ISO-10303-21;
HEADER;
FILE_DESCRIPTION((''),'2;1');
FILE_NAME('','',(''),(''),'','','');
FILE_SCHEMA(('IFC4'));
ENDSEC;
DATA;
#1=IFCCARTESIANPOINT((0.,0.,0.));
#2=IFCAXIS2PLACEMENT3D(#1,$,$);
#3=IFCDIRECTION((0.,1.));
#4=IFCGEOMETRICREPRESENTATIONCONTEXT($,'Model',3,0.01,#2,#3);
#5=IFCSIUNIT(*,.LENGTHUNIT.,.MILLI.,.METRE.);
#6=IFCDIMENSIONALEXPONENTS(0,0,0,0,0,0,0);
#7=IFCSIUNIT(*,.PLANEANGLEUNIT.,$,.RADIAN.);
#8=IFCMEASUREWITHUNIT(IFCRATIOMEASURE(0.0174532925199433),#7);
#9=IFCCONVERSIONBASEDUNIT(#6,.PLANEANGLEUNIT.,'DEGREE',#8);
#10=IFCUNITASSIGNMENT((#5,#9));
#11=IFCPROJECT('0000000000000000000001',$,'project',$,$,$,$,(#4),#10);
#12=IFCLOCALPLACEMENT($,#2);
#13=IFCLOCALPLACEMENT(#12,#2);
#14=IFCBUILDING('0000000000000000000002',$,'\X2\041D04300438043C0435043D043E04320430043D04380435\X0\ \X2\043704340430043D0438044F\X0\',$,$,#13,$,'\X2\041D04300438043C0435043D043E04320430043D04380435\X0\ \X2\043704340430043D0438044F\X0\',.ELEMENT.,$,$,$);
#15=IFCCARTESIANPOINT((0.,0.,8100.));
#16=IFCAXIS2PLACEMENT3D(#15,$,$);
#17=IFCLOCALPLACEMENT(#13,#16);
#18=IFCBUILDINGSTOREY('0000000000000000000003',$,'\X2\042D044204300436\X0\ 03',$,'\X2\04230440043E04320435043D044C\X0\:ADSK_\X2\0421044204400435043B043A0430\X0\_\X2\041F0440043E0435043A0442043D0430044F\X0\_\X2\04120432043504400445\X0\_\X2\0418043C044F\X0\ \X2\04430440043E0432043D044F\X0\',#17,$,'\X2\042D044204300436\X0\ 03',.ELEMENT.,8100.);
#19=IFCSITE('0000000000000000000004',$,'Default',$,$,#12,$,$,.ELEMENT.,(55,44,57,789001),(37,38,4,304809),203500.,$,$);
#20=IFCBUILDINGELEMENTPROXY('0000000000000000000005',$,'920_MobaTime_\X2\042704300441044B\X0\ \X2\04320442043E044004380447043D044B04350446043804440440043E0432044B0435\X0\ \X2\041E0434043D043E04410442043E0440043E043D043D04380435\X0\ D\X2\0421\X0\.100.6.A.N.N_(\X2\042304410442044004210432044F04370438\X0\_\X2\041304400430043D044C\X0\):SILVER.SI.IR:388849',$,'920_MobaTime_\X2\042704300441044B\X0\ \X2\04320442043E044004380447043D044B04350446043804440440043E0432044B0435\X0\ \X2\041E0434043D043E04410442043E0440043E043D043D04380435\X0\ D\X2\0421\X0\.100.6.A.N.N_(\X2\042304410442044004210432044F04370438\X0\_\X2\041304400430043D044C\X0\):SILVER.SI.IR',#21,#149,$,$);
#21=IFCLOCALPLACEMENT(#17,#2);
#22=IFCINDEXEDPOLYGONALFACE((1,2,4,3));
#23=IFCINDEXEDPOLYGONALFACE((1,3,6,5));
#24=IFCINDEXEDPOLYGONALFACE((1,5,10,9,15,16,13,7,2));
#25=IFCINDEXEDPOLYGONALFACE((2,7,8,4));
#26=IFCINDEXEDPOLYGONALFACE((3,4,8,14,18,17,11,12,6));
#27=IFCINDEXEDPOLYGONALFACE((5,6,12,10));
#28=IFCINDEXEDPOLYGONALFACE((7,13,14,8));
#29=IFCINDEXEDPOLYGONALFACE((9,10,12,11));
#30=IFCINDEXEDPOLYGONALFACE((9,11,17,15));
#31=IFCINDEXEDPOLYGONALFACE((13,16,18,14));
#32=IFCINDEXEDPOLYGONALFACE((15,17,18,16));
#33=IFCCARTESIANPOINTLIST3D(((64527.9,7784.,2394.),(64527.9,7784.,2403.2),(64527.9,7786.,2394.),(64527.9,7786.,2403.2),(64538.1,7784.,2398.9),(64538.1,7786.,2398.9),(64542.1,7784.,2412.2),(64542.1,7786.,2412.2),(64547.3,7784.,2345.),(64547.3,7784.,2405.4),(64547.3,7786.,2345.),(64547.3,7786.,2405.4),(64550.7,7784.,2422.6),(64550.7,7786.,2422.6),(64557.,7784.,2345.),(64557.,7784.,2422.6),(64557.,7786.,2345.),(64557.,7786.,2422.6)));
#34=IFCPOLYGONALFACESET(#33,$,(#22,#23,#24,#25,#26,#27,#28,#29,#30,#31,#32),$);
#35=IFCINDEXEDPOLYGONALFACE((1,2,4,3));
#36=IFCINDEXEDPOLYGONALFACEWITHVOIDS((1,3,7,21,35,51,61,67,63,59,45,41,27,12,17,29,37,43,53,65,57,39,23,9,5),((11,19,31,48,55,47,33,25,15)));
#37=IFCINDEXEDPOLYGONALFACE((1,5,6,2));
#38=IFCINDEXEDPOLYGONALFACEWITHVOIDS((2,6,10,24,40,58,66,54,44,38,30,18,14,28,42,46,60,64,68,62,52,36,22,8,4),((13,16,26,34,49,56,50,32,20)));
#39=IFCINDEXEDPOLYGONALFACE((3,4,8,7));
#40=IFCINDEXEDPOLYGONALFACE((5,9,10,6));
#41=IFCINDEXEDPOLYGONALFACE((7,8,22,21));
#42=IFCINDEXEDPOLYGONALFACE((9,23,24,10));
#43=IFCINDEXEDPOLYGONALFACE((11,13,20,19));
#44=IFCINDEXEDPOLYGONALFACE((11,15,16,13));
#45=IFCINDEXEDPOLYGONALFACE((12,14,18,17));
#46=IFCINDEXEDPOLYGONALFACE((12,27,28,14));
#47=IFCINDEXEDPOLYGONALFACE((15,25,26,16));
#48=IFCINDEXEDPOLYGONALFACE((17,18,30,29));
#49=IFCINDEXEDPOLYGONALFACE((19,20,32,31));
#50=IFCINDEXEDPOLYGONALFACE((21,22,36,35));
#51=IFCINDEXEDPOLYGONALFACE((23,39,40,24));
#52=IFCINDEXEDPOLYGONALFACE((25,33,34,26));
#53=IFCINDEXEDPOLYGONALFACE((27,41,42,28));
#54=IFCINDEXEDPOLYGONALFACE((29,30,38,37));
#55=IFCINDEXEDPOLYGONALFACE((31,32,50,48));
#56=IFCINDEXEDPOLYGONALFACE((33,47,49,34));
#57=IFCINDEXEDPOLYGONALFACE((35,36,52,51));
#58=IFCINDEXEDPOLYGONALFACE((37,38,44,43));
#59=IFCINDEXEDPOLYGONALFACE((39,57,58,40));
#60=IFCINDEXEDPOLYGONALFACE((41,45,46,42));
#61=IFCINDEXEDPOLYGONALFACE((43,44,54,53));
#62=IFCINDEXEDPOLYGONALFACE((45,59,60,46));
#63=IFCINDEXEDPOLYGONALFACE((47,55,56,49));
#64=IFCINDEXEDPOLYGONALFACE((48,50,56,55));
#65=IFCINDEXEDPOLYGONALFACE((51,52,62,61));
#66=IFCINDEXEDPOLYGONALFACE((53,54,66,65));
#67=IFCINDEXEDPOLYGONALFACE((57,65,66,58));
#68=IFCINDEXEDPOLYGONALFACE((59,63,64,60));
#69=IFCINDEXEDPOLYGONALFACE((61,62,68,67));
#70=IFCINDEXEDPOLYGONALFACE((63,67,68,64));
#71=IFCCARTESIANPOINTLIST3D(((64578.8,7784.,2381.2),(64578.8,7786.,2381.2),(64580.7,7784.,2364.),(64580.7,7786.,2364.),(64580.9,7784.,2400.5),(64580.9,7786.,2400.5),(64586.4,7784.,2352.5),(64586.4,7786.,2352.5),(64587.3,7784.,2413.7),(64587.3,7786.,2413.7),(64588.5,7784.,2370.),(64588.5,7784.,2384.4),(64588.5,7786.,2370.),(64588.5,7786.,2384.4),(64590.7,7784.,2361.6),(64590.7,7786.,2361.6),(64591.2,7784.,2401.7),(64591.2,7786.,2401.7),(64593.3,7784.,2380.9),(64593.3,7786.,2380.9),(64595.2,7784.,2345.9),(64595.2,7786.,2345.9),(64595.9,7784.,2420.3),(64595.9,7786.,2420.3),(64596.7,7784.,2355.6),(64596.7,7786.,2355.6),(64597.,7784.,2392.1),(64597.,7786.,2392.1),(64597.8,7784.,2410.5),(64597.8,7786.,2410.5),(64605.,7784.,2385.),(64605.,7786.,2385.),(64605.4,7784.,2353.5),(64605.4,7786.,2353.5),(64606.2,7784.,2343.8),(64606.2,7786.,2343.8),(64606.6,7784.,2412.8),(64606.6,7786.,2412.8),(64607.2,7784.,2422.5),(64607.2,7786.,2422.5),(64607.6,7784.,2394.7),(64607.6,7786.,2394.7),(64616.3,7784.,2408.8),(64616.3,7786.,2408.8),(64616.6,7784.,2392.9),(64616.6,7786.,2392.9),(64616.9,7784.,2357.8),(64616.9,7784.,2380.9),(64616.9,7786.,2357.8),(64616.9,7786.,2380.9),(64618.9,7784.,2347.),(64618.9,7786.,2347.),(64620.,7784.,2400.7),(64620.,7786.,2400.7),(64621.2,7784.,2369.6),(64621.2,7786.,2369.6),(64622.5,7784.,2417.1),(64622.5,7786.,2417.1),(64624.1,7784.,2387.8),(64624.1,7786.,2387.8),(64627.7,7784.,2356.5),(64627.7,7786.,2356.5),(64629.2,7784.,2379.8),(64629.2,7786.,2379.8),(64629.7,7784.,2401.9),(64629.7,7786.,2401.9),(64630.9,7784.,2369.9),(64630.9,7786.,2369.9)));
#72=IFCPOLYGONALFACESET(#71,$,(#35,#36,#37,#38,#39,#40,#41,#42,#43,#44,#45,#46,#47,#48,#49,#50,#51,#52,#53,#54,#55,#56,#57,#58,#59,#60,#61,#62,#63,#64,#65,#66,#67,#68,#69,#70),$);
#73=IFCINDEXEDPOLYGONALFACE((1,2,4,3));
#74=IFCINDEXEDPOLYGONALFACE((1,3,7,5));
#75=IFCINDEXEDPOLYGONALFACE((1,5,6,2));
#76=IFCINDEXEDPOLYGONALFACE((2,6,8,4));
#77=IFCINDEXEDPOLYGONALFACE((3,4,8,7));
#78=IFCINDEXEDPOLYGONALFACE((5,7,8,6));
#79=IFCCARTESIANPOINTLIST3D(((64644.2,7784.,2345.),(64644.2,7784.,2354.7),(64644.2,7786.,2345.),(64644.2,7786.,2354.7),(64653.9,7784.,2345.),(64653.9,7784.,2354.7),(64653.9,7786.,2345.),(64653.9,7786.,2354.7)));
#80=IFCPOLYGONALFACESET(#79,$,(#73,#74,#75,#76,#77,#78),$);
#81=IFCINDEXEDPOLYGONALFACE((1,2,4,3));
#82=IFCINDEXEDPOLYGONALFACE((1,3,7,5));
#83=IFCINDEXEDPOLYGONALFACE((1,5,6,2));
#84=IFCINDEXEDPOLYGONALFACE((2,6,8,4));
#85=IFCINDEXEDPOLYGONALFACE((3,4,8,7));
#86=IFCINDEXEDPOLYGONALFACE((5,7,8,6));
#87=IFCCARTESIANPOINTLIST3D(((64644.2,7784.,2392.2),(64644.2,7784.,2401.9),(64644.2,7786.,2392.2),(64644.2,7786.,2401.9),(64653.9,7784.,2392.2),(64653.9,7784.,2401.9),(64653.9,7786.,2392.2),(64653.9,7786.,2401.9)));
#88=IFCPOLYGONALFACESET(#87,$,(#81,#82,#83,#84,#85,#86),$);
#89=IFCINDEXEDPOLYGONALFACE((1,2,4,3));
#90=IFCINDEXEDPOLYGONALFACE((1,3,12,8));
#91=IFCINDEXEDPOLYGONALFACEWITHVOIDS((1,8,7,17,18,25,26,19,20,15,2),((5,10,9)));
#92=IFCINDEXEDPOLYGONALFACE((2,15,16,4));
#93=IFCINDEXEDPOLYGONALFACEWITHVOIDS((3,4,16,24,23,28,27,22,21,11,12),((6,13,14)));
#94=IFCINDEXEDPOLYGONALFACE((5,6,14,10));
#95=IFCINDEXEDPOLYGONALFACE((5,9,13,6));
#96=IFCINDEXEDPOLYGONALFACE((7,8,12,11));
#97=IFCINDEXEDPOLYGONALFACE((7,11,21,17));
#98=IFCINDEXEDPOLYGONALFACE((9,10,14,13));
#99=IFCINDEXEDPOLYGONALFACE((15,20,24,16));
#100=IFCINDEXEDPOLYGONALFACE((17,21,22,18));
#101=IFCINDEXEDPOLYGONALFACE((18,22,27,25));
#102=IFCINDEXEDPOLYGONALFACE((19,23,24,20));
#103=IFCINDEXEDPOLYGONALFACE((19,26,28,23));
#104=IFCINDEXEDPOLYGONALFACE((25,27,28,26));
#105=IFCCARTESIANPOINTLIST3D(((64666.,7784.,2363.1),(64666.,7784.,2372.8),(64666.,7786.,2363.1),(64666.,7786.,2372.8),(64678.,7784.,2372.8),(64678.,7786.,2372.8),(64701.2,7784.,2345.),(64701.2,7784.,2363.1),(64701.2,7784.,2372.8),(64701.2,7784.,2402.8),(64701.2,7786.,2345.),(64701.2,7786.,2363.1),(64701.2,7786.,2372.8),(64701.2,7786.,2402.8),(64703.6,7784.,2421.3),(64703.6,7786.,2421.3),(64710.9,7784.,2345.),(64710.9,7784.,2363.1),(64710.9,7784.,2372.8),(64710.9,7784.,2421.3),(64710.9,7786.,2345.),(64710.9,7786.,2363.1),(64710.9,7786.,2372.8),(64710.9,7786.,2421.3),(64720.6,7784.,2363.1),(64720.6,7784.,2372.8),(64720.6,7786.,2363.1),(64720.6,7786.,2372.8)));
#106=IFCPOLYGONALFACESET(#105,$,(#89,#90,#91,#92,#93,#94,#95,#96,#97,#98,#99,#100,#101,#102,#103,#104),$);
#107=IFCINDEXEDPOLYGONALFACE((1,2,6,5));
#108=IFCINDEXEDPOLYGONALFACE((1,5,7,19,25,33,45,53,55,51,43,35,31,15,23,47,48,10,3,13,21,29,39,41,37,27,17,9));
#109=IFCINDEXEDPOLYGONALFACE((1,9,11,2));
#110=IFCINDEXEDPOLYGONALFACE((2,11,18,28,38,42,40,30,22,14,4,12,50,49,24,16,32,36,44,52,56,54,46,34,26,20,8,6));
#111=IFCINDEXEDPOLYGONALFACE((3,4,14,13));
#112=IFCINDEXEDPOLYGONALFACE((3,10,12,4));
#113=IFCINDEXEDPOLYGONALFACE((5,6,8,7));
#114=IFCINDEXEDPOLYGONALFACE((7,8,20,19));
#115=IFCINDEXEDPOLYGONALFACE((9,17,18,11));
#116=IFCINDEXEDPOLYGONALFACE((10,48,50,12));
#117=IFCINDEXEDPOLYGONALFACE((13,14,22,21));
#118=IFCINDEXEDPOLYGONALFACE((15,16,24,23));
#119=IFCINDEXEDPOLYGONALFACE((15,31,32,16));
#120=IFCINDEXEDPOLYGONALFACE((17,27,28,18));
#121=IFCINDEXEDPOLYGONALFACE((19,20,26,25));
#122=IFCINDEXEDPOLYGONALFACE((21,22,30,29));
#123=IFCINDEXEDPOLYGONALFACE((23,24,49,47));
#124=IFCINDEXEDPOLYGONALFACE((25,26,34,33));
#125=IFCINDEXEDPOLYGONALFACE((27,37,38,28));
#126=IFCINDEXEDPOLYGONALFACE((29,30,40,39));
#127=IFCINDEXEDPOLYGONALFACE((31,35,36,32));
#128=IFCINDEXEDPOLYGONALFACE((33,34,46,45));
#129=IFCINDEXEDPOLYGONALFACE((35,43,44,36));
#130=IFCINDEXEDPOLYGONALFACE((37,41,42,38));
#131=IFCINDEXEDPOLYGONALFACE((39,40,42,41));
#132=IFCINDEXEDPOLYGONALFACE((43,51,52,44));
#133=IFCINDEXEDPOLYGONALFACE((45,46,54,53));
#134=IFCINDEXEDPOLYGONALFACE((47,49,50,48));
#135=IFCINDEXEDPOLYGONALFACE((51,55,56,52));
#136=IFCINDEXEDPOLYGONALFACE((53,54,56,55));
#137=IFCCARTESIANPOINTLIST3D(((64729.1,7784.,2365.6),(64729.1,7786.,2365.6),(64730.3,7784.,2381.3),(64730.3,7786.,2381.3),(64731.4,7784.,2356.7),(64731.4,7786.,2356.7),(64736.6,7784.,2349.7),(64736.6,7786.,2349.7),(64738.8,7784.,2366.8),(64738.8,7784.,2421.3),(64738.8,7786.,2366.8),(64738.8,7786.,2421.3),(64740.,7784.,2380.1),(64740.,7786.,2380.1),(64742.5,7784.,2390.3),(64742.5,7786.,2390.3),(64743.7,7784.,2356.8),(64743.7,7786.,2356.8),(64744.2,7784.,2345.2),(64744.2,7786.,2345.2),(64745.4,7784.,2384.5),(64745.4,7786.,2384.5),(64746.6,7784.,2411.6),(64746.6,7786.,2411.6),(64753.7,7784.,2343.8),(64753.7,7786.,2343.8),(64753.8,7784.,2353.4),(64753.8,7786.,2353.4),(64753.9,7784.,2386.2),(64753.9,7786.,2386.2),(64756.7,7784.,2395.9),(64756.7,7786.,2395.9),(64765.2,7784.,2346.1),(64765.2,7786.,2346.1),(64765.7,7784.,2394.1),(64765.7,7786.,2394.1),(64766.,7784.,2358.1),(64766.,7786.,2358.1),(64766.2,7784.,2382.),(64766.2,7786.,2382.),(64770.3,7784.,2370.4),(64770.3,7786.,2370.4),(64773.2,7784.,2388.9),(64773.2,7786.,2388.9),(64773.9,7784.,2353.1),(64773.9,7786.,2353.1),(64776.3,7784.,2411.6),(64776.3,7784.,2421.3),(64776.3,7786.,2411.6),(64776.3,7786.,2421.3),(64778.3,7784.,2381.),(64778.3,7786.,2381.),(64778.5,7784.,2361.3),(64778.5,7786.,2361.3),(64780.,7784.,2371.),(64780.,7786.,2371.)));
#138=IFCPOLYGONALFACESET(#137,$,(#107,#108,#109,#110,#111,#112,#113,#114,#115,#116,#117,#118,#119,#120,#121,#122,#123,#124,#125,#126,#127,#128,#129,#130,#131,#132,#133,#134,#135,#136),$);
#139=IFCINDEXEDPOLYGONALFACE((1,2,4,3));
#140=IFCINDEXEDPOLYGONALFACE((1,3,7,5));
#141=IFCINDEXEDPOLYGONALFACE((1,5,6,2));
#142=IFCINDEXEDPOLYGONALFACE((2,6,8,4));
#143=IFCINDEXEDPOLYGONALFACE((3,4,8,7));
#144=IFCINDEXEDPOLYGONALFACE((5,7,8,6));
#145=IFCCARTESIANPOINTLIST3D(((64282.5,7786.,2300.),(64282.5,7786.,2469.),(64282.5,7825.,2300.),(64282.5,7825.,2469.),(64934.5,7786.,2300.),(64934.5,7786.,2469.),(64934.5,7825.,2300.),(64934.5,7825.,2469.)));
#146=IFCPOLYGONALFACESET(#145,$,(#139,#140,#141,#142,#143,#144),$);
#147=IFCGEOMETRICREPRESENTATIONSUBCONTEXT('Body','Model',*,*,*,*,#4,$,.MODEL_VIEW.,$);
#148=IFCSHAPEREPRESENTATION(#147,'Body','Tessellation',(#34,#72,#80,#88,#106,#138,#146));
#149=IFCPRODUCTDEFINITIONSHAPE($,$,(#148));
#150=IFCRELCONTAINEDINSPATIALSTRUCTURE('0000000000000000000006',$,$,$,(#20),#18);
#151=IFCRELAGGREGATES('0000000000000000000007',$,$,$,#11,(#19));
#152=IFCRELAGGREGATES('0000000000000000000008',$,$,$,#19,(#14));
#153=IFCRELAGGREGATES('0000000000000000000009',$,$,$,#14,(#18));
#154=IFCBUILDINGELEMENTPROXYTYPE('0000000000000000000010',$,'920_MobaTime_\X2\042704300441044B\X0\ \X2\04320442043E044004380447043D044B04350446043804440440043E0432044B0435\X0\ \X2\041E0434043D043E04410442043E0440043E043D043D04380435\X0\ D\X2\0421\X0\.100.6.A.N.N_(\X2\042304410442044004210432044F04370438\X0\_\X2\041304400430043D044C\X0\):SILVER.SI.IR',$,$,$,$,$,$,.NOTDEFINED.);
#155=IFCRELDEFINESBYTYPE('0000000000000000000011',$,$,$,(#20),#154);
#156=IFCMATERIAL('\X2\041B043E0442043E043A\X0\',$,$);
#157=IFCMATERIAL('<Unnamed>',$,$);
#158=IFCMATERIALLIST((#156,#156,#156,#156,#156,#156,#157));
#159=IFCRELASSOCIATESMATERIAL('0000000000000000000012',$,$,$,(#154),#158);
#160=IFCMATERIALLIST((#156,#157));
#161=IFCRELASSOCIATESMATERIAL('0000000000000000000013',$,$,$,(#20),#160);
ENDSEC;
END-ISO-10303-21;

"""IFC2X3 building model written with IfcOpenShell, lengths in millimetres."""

from ifc_helpers import new_model, entity, si_unit, converted_unit, direction, frame, origin, origin_2d_with_axis, place, context, subcontext, project, spatial, polyline, rectangle, outline, extrude, source, transform, mapped, material, material_list, type_object, type_shapes, element, save


model = new_model("IFC2X3")

# Units and contexts
model_context = context("Model", 3, precision=0.01, world=origin(), true_north=direction((0.0, 1.0)))
body_context = subcontext(model_context, "Body", "Model", "MODEL_VIEW")
ifc_project = project(units=[si_unit("LENGTHUNIT", "METRE", prefix="MILLI"), converted_unit("PLANEANGLEUNIT", "DEGREE", entity("IfcRatioMeasure", 0.0174532925199433), si_unit("PLANEANGLEUNIT", "RADIAN"), dimensions=[0, 0, 0, 0, 0, 0, 0])], contexts=[model_context])

# Site, building, storey
site_placement = place(None, origin())
site = spatial("IfcSite", under=ifc_project, at=site_placement, Name="Default", CompositionType="ELEMENT", RefLatitude=(55, 44, 57, 789001), RefLongitude=(37, 38, 4, 304809), RefElevation=203500.0)
building_placement = place(site_placement, origin())
building = spatial("IfcBuilding", under=site, at=building_placement, Name="Наименование здания", LongName="Наименование здания", CompositionType="ELEMENT")
storey_placement = place(building_placement, frame((0.0, 0.0, 8100.0)))
storey = spatial("IfcBuildingStorey", under=building, at=storey_placement, Name="Этаж 03", ObjectType="Уровень:ADSK_Стрелка_Проектная_Вверх_Имя уровня", LongName="Этаж 03", CompositionType="ELEMENT", Elevation=8100.0)

# Building element proxy
ifc_material_1 = material(Name="Лоток")
ifc_material_2 = material(Name="<Unnamed>")
ifc_material_list_1 = material_list([ifc_material_1, ifc_material_1, ifc_material_1, ifc_material_1, ifc_material_1, ifc_material_1, ifc_material_2])
building_element_proxy_type = type_object("IfcBuildingElementProxyType", Name="920_MobaTime_Часы вторичныецифровые Односторонние DС.100.6.A.N.N_(УстрСвязи_Грань):SILVER.SI.IR", PredefinedType="NOTDEFINED", material=ifc_material_list_1)
shared_shape = source(origin(), body_context, "Body", "SweptSolid", [
    extrude(outline(polyline([(-49.3, -13.1), (28.2, -13.1), (28.2, -6.8), (17.9, 1.8), (8.8, 16.0), (-0.3, 16.0), (4.6, 5.8), (11.1, -3.4), (-49.3, -3.4), (-49.3, -13.1)])), frame((-64.6, 9.8, 39.0), z_axis=(0.0, 0.0, 1.0), x_axis=(0.0, 1.0, 0.0)), (0.0, 0.0, 1.0), 2.0),
    extrude(outline(polyline([(2.2, -27.6), (19.0, -27.6), (30.5, -16.1), (33.3, -4.9), (31.0, 5.8), (21.8, 17.2), (5.2, 27.3), (-11.1, 33.0), (-24.0, 32.7), (-33.6, 27.6), (-40.3, 18.6), (-42.8, 5.7), (-38.0, -6.3), (-27.2, -14.9), (-17.5, -17.7), (-8.2, -16.4), (-0.3, -11.9), (5.1, -4.5), (7.3, 6.2), (4.0, 17.2), (18.4, 7.3), (23.6, -2.4), (22.0, -11.4), (14.2, -18.4), (5.3, -18.3), (2.2, -27.6)]), holes=[polyline([(-9.0, 23.3), (-1.3, 14.3), (-2.5, 2.0), (-11.4, -7.0), (-23.4, -6.0), (-32.2, 2.9), (-31.2, 15.1), (-25.6, 22.1), (-17.5, 24.9), (-9.0, 23.3)])]), frame((-2.7, 3.6, 39.0), z_axis=(0.0, 0.0, 1.0), x_axis=(-0.427649, 0.903945, 0.0)), (0.0, 0.0, 1.0), 2.0),
    extrude(rectangle(XDim=9.7, YDim=9.7, at=origin_2d_with_axis()), frame((40.6, -34.7, 39.0)), (0.0, 0.0, 1.0), 2.0),
    extrude(rectangle(XDim=9.7, YDim=9.7, at=origin_2d_with_axis()), frame((40.6, 12.6, 39.0)), (0.0, 0.0, 1.0), 2.0),
    extrude(outline(polyline([(-0.9, -28.1), (8.8, -28.1), (8.8, -9.9), (18.5, -9.9), (18.5, -0.2), (8.8, -0.2), (8.8, 48.3), (1.5, 48.3), (-36.0, -0.2), (-36.0, -9.9), (-0.9, -9.9), (-0.9, -28.1)]), holes=[polyline([(-0.9, -0.2), (-24.1, -0.2), (-0.9, 29.7), (-0.9, -0.2)])]), frame((93.6, -11.4, 39.0)), (0.0, 0.0, 1.0), 2.0),
    extrude(outline(polyline([(3.3, -28.3), (12.5, -28.3), (20.5, -25.0), (26.8, -18.9), (30.7, -10.0), (31.4, 1.6), (26.9, 11.8), (20.1, 18.4), (11.1, 22.3), (1.0, 23.3), (-7.9, 20.4), (-14.9, 14.5), (-18.9, 6.2), (-17.1, -9.0), (-36.7, 0.5), (-29.1, 29.2), (-38.5, 31.7), (-48.1, -4.6), (-11.6, -23.1), (-8.0, -14.0), (-10.8, -7.6), (-10.2, 1.1), (-3.0, 11.8), (9.2, 12.8), (20.0, 5.5), (21.4, -7.5), (15.5, -16.4), (4.6, -18.6), (3.3, -28.3)])), frame((147.1, -8.5, 39.0), z_axis=(0.0, 0.0, 1.0), x_axis=(0.256974, -0.966418, 0.0)), (0.0, 0.0, 1.0), 2.0),
    extrude(rectangle(XDim=652.0, YDim=169.0, at=origin_2d_with_axis()), frame((0.0, 0.0, 0.0), z_axis=(0.0, 0.0, 1.0), x_axis=(-1.0, 0.0, 0.0)), (0.0, 0.0, 1.0), 39.0),
])
type_shapes(building_element_proxy_type, [shared_shape])
ifc_material_list_2 = material_list([ifc_material_1, ifc_material_2])
for number, where, z_axis, x_axis, name in (
    (1, (64608.5, 7825.0, 2384.5), (0.0, -1.0, 0.0), (1.0, 0.0, 0.0), "920_MobaTime_Часы вторичныецифровые Односторонние DС.100.6.A.N.N_(УстрСвязи_Грань):SILVER.SI.IR:388849"),
):
    element("IfcBuildingElementProxy", number, at=place(storey_placement, frame(where, z_axis=z_axis, x_axis=x_axis)), inside=storey, type_object=building_element_proxy_type, material=ifc_material_list_2, Name=name, ObjectType="920_MobaTime_Часы вторичныецифровые Односторонние DС.100.6.A.N.N_(УстрСвязи_Грань):SILVER.SI.IR", context=body_context, shape_type="MappedRepresentation", body=[
        mapped(shared_shape, transform((0.0, 0.0, 0.0), scale=1.0)),
    ])

save(model, "model.ifc")
